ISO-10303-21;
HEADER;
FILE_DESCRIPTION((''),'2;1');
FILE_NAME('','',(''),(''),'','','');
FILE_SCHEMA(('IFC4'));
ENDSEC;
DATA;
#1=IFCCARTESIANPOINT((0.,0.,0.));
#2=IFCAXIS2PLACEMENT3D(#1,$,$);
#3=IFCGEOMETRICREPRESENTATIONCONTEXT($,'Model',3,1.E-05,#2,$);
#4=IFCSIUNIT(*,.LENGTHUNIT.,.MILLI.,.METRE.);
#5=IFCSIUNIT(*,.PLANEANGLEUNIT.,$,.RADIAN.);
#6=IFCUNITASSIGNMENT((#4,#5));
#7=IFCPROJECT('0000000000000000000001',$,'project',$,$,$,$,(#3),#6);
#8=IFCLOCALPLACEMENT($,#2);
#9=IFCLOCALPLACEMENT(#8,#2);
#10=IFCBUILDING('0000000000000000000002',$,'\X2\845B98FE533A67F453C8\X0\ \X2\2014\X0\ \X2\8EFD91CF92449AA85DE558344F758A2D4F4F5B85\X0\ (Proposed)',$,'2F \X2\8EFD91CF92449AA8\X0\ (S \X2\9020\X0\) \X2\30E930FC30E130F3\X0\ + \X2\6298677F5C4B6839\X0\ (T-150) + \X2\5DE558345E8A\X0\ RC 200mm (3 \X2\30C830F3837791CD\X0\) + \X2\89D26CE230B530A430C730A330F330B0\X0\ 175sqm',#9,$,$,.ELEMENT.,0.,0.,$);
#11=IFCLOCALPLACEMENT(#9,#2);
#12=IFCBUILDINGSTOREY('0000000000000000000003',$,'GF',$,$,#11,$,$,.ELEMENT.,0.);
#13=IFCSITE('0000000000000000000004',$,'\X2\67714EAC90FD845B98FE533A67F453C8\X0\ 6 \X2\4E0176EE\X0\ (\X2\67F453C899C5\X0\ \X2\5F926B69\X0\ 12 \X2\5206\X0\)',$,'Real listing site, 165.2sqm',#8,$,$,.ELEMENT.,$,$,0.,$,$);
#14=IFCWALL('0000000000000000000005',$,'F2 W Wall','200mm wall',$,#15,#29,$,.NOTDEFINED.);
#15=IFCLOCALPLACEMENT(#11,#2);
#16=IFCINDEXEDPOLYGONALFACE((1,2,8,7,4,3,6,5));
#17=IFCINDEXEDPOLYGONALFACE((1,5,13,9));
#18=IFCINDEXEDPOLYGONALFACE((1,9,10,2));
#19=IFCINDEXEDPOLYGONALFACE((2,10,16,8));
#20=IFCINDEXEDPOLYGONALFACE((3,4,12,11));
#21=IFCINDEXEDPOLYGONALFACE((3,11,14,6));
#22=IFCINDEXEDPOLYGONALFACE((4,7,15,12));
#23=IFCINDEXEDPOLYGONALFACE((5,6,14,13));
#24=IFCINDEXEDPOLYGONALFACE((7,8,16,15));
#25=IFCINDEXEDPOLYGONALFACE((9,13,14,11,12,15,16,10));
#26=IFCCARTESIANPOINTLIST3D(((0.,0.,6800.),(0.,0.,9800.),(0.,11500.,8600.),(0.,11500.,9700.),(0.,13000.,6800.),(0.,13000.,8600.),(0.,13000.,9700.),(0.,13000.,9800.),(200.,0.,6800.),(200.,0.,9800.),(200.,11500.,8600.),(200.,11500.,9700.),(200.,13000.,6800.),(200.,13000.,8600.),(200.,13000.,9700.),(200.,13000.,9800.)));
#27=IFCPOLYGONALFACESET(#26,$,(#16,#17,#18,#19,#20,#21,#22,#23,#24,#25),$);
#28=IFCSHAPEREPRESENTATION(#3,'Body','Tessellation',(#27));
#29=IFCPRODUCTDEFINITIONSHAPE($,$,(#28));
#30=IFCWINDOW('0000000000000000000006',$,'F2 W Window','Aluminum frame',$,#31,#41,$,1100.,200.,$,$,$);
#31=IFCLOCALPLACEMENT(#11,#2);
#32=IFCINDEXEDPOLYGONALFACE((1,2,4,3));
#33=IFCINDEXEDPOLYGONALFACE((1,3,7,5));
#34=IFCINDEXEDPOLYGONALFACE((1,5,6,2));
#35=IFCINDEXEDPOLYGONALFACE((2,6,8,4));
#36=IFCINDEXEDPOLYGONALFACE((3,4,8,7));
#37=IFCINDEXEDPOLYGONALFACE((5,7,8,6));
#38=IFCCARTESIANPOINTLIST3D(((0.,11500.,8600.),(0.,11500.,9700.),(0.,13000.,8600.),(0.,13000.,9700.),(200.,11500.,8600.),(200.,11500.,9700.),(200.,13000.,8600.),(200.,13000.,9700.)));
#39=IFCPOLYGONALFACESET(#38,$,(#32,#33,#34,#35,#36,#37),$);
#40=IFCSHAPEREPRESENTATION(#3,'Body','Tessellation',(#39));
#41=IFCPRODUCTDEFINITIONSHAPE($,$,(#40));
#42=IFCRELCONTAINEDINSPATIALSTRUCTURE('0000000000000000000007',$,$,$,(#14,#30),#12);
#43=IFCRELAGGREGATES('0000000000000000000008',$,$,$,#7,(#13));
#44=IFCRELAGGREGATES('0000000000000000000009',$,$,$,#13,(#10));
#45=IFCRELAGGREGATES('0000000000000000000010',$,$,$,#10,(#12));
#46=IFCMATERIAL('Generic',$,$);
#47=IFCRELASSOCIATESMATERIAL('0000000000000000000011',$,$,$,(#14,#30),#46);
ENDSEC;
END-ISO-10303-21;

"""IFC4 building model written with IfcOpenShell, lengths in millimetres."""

from ifc_helpers import new_model, si_unit, frame, frame_2d, origin, place, context, project, spatial, rectangle, extrude, material, element, fill, save


model = new_model("IFC4")

# Units and contexts
model_context = context("Model", 3, precision=1e-05, world=origin())
ifc_project = project(units=[si_unit("LENGTHUNIT", "METRE", prefix="MILLI"), si_unit("PLANEANGLEUNIT", "RADIAN")], contexts=[model_context])

# Site, building, storey
site_placement = place(None, origin())
site = spatial("IfcSite", under=ifc_project, at=site_placement, Name="東京都葛飾区柴又 6 丁目 (柴又駅 徒歩 12 分)", ObjectType="Real listing site, 165.2sqm", CompositionType="ELEMENT", RefElevation=0.0)
building_placement = place(site_placement, origin())
building = spatial("IfcBuilding", under=site, at=building_placement, Name="葛飾区柴又 — 軽量鉄骨工場併設住宅 (Proposed)", ObjectType="2F 軽量鉄骨 (S 造) ラーメン + 折板屋根 (T-150) + 工場床 RC 200mm (3 トン荷重) + 角波サイディング 175sqm", CompositionType="ELEMENT", ElevationOfRefHeight=0.0, ElevationOfTerrain=0.0)
storey_placement = place(building_placement, origin())
storey = spatial("IfcBuildingStorey", under=building, at=storey_placement, Name="GF", CompositionType="ELEMENT", Elevation=0.0)

# Shared definitions
ifc_material_1 = material(Name="Generic")

# Wall, opening, window
wall_1_placement = place(storey_placement, frame((0.0, 0.0, 3400.0)))
wall_1 = element("IfcWall", 1, at=wall_1_placement, inside=storey, material=ifc_material_1, Name="F2 W Wall", Description="200mm wall", PredefinedType="NOTDEFINED", context=model_context, shape_type="SweptSolid", body=[
    extrude(rectangle(XDim=200.0, YDim=13000.0, at=frame_2d((100.0, 6500.0))), frame((0.0, 0.0, 3400.0)), (0.0, 0.0, 1.0), 3000.0),
])
opening_1_placement = place(storey_placement, frame((0.0, 5750.0, 4300.0)))
opening_1 = element("IfcOpeningElement", 2, at=opening_1_placement, cuts=wall_1, PredefinedType="NOTDEFINED", context=model_context, shape_type="SweptSolid", body=[
    extrude(rectangle(XDim=200.0, YDim=1500.0, at=frame_2d((100.0, 750.0))), frame((0.0, 5750.0, 4300.0)), (0.0, 0.0, 1.0), 1100.0),
])
window_1_placement = place(storey_placement, frame((0.0, 5750.0, 4300.0)))
window_1 = element("IfcWindow", 3, at=window_1_placement, inside=storey, material=ifc_material_1, Name="F2 W Window", Description="Aluminum frame", OverallHeight=1100.0, OverallWidth=200.0, context=model_context, shape_type="SweptSolid", body=[
    extrude(rectangle(XDim=200.0, YDim=1500.0, at=frame_2d((100.0, 750.0))), frame((0.0, 5750.0, 4300.0)), (0.0, 0.0, 1.0), 1100.0),
])
fill(opening_1, window_1)

save(model, "model.ifc")
